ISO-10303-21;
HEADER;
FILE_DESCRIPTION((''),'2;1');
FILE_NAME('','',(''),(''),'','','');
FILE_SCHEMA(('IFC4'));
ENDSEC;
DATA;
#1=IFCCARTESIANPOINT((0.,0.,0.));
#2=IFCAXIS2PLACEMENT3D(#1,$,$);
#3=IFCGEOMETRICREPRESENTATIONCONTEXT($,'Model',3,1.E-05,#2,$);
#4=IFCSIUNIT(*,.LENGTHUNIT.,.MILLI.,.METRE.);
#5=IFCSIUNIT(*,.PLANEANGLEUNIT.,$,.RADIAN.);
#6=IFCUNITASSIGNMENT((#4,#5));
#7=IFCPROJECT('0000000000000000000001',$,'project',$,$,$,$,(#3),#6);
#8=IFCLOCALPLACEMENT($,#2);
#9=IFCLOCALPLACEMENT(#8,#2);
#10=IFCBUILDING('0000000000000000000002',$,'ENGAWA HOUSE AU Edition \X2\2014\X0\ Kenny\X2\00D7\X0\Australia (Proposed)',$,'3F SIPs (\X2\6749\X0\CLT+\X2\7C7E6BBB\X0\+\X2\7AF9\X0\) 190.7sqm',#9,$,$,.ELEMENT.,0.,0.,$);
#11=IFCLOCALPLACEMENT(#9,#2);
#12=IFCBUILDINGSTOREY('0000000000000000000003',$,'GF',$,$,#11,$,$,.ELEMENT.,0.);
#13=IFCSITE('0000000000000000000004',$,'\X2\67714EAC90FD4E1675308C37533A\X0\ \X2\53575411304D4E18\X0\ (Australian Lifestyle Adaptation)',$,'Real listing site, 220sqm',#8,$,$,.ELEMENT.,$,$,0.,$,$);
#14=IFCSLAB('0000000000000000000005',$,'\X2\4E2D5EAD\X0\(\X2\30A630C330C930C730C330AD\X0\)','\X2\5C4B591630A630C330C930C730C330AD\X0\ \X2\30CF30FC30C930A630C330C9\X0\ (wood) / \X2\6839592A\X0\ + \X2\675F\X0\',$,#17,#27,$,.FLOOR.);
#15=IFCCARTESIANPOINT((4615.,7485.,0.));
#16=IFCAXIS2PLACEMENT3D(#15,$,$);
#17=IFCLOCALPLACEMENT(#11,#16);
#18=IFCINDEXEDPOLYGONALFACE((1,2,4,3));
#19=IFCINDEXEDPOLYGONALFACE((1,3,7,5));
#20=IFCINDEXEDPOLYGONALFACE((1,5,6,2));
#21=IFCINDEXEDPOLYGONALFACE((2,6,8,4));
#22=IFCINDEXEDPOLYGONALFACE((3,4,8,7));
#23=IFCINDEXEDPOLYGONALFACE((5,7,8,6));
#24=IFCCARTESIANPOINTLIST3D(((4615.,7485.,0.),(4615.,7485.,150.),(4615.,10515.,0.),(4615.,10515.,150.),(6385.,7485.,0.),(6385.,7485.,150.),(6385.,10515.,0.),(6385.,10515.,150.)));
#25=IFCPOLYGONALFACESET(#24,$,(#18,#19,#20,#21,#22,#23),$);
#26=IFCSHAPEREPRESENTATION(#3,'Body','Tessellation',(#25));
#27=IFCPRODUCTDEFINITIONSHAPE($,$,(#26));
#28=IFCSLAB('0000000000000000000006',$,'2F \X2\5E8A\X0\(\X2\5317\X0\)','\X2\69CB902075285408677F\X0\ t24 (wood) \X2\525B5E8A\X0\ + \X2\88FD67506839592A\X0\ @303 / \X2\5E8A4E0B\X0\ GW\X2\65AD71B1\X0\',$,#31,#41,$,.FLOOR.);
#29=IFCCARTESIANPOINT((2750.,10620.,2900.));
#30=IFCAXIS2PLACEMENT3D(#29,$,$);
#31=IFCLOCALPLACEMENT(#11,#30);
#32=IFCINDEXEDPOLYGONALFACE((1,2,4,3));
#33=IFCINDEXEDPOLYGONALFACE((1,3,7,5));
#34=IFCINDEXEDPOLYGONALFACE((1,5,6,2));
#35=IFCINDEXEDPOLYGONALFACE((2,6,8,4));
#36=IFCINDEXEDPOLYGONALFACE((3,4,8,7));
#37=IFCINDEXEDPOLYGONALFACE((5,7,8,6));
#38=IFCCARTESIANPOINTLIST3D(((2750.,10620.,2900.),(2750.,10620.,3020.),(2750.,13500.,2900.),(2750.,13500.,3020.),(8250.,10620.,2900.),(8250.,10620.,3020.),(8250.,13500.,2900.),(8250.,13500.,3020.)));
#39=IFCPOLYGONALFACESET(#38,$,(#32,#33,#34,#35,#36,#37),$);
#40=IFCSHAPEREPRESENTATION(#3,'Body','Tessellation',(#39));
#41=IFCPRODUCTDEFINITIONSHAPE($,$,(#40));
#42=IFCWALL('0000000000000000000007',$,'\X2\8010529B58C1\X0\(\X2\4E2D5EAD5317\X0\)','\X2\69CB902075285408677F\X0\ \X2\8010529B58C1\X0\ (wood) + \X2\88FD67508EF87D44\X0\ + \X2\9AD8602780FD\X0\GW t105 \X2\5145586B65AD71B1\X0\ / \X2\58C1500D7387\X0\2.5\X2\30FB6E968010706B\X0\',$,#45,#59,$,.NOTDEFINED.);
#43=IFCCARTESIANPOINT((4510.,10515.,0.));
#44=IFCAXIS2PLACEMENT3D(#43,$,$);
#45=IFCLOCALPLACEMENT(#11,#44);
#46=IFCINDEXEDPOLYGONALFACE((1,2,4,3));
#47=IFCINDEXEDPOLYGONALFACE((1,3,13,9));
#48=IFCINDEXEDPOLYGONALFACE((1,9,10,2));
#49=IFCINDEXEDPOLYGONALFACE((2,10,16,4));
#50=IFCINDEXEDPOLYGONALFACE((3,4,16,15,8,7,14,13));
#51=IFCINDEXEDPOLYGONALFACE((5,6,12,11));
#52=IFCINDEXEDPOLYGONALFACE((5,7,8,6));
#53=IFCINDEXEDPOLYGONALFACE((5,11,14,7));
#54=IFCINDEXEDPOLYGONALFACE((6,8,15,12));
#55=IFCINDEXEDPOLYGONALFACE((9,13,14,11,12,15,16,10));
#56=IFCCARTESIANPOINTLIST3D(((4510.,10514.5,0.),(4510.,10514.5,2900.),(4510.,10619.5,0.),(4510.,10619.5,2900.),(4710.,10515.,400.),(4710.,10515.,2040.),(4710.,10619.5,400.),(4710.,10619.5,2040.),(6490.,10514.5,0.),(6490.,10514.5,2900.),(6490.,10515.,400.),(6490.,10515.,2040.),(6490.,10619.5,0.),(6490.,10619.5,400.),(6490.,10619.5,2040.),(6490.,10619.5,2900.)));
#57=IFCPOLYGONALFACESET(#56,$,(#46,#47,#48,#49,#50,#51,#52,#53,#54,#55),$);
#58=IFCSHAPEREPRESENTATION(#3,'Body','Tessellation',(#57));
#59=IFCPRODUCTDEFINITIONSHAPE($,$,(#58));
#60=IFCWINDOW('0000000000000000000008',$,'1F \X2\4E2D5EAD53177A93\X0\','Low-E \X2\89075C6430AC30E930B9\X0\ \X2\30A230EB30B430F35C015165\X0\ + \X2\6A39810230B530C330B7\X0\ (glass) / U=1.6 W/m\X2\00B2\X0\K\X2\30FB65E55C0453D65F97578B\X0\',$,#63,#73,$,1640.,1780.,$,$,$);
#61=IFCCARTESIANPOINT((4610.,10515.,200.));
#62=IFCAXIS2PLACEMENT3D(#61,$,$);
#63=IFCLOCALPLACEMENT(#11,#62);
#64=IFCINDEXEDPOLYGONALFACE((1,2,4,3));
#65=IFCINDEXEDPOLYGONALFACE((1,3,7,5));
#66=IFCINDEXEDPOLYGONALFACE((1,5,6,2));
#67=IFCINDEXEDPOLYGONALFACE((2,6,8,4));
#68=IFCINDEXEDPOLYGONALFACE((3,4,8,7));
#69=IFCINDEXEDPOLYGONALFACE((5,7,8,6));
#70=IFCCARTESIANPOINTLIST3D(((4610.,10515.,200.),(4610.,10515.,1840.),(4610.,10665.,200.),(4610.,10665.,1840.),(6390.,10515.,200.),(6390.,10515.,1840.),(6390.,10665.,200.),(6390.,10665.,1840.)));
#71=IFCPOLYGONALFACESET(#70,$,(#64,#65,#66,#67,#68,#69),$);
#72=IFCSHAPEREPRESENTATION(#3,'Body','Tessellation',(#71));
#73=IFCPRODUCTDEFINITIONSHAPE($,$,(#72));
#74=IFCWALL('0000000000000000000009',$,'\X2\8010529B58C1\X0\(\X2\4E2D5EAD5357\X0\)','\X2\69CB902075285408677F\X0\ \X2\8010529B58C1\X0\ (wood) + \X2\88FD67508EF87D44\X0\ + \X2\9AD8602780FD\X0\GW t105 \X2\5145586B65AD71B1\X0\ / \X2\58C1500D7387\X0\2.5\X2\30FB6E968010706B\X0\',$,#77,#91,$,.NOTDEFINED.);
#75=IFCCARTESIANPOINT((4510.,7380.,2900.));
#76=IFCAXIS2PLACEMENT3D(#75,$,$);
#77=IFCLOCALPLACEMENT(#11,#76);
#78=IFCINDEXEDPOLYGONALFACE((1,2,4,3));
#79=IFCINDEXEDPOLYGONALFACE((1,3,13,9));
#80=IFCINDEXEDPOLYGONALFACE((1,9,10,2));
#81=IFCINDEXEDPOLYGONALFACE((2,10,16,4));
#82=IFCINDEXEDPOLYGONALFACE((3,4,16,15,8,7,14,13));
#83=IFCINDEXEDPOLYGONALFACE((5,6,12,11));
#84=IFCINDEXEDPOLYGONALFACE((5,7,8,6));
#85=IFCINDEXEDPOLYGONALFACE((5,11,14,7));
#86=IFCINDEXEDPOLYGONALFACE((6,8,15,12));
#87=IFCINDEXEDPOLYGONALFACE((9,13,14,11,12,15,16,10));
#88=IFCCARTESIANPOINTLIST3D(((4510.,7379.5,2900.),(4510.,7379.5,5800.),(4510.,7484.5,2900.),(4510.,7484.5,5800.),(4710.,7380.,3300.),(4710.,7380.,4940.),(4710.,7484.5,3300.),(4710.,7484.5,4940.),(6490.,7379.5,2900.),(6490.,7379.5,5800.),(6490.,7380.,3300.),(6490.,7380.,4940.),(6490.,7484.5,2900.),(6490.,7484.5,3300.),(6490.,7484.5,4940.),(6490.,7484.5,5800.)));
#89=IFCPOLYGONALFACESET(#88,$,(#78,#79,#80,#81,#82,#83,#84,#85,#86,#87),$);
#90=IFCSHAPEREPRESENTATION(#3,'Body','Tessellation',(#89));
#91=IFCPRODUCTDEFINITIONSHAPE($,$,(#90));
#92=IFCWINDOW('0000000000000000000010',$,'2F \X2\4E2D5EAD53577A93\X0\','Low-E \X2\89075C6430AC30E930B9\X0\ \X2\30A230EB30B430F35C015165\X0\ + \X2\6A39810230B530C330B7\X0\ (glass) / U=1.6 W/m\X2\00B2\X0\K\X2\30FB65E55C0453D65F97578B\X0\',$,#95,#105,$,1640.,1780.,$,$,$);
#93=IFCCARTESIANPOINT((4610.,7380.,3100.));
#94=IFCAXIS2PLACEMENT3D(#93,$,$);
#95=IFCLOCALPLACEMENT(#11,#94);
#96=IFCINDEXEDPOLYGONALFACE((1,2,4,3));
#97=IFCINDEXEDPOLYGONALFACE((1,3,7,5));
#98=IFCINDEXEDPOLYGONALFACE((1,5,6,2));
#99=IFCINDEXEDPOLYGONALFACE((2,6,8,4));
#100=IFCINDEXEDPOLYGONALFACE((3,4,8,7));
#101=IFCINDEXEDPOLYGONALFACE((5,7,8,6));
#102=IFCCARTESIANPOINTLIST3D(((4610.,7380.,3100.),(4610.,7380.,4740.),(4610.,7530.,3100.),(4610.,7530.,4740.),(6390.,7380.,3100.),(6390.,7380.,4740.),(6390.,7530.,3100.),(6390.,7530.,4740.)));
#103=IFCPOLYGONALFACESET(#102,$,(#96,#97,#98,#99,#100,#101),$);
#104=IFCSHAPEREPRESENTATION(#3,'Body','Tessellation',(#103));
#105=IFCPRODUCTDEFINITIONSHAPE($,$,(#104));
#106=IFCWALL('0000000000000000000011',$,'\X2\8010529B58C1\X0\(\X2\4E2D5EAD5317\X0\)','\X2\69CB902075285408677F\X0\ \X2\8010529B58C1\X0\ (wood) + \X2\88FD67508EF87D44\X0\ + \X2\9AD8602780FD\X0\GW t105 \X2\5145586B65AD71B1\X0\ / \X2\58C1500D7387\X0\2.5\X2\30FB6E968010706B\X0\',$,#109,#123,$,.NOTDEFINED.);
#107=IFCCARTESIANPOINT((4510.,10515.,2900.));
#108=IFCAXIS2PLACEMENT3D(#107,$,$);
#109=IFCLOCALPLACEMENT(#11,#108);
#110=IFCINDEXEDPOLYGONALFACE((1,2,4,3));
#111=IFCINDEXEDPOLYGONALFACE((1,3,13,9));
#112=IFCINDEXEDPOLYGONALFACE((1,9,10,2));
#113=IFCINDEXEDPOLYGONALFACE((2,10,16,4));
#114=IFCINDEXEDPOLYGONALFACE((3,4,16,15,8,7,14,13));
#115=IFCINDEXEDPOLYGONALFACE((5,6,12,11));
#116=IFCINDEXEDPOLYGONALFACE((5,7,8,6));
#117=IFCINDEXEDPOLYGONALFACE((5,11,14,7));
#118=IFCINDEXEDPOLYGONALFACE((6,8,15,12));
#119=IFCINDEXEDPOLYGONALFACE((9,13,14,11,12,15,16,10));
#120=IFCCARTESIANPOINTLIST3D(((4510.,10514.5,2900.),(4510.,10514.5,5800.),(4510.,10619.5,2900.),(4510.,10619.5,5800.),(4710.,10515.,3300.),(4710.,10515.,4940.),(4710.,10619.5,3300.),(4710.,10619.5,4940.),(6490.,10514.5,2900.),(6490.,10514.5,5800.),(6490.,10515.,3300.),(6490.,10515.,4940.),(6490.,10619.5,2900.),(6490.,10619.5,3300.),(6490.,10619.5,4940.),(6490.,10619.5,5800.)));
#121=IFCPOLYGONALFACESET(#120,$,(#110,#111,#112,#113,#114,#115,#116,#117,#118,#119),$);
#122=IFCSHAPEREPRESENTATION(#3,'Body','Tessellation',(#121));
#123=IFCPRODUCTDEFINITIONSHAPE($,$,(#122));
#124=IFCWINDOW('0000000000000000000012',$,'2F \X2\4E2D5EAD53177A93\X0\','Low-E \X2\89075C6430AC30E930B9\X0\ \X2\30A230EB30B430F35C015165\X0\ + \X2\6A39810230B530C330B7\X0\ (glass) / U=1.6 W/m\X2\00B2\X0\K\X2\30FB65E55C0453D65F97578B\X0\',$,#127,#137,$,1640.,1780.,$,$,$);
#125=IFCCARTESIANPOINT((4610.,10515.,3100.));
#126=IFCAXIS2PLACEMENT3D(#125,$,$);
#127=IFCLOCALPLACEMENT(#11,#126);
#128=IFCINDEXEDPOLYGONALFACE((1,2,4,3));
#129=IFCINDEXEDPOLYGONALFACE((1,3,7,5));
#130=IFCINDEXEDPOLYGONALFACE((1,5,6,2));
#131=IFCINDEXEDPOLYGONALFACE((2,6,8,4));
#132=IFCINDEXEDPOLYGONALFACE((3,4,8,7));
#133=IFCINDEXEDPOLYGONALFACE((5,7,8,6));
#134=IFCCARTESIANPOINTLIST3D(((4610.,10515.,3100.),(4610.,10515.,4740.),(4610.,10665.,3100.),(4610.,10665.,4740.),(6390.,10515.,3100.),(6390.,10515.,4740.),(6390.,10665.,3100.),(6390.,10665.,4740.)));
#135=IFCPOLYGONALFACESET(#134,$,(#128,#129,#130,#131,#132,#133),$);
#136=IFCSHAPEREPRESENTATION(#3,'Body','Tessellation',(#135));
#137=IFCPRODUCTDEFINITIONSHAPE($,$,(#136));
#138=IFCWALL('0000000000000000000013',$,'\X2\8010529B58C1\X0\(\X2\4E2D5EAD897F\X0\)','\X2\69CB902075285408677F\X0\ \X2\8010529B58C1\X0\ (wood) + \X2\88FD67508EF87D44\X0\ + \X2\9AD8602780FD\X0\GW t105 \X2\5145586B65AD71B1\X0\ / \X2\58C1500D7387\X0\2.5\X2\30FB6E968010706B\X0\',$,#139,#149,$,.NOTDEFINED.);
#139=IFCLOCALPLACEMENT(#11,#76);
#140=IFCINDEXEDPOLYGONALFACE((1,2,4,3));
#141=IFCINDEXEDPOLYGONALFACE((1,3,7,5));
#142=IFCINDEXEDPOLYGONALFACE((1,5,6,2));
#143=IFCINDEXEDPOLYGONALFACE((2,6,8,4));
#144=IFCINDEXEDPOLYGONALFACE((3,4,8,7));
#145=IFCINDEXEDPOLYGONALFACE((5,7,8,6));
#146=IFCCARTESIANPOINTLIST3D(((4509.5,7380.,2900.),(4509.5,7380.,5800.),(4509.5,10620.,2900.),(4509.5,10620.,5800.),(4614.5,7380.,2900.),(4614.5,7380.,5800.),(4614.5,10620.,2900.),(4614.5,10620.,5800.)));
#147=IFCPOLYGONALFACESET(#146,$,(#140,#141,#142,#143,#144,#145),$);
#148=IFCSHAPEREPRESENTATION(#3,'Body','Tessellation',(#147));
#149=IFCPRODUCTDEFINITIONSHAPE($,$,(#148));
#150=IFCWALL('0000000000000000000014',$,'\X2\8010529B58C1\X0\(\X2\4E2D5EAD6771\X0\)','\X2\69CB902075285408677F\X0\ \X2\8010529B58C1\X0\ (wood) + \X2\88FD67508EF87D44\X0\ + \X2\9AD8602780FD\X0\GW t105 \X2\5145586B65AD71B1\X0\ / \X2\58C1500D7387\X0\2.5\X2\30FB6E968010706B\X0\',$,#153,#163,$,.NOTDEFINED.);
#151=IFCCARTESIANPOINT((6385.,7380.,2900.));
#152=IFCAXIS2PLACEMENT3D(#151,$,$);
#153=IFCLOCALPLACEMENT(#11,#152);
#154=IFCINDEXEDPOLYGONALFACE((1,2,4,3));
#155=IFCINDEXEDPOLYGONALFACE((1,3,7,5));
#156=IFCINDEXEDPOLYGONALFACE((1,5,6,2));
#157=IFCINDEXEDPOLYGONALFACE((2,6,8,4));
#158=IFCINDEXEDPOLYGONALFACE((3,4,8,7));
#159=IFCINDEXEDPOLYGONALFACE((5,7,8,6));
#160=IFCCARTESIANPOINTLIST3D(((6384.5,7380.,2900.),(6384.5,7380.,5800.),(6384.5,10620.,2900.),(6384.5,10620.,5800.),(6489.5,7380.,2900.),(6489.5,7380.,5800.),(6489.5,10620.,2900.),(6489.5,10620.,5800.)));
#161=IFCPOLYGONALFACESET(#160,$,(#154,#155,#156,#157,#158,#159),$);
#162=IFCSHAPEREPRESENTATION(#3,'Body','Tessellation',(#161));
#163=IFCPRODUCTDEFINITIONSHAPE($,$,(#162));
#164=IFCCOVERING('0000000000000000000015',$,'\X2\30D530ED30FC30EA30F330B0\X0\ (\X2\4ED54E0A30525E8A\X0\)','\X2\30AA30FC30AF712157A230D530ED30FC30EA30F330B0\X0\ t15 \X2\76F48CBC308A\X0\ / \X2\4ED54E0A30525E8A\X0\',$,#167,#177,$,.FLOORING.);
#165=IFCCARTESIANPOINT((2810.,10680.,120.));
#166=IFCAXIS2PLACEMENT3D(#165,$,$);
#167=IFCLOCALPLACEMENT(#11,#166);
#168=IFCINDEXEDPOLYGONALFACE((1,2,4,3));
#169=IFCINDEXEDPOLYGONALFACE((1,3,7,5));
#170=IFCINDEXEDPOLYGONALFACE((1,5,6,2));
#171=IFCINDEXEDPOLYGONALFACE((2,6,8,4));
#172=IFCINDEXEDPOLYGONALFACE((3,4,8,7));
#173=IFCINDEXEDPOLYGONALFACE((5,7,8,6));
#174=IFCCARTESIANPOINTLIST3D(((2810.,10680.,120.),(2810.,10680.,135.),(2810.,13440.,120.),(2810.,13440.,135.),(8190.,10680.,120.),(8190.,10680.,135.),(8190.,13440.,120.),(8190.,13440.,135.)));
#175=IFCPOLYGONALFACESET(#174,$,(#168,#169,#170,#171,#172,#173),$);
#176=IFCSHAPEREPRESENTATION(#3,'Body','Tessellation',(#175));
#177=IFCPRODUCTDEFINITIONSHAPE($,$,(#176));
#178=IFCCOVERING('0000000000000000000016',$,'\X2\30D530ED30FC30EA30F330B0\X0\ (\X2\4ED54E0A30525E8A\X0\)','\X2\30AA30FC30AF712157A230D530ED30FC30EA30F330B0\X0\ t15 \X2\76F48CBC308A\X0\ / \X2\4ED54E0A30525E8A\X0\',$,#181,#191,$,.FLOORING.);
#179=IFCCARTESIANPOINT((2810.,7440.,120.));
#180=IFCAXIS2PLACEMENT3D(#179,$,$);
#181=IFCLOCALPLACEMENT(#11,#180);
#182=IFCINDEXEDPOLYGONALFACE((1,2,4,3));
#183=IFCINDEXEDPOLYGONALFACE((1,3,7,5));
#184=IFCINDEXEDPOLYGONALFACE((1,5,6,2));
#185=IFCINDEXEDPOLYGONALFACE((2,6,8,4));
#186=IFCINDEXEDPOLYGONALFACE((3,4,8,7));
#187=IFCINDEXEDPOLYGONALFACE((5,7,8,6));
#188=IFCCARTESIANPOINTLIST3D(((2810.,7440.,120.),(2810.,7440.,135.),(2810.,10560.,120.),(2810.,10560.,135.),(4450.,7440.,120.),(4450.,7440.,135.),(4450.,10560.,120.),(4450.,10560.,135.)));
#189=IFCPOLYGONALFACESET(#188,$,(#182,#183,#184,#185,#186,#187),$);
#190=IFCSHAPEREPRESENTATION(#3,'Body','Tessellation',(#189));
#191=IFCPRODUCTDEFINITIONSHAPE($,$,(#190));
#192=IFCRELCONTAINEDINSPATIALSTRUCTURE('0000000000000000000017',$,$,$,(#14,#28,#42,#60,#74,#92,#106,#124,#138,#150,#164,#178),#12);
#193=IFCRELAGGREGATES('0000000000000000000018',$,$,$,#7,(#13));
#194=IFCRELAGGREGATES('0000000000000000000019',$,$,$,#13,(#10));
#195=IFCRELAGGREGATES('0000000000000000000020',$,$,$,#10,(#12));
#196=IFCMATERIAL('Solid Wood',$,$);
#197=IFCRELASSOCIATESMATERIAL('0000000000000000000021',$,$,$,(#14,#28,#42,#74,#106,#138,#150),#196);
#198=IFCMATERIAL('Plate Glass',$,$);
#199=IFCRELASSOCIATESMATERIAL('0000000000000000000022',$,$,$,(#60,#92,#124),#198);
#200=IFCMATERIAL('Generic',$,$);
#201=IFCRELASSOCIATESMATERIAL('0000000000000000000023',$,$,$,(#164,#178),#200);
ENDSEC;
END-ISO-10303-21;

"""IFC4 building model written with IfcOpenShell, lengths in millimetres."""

from ifc_helpers import new_model, si_unit, frame, frame_2d, origin, place, context, project, spatial, rectangle, extrude, material, element, fill, save


model = new_model("IFC4")

# Units and contexts
model_context = context("Model", 3, precision=1e-05, world=origin())
ifc_project = project(units=[si_unit("LENGTHUNIT", "METRE", prefix="MILLI"), si_unit("PLANEANGLEUNIT", "RADIAN")], contexts=[model_context])

# Site, building, storey
site_placement = place(None, origin())
site = spatial("IfcSite", under=ifc_project, at=site_placement, Name="東京都世田谷区 南向き丘 (Australian Lifestyle Adaptation)", ObjectType="Real listing site, 220sqm", CompositionType="ELEMENT", RefElevation=0.0)
building_placement = place(site_placement, origin())
building = spatial("IfcBuilding", under=site, at=building_placement, Name="ENGAWA HOUSE AU Edition — Kenny×Australia (Proposed)", ObjectType="3F SIPs (杉CLT+籾殻+竹) 190.7sqm", CompositionType="ELEMENT", ElevationOfRefHeight=0.0, ElevationOfTerrain=0.0)
storey_placement = place(building_placement, origin())
storey = spatial("IfcBuildingStorey", under=building, at=storey_placement, Name="GF", CompositionType="ELEMENT", Elevation=0.0)

# Slabs
ifc_material_1 = material(Name="Solid Wood")
slab_1_placement = place(storey_placement, frame((4615.0, 7485.0, 0.0)))
element("IfcSlab", 1, at=slab_1_placement, inside=storey, material=ifc_material_1, Name="中庭(ウッドデッキ)", Description="屋外ウッドデッキ ハードウッド (wood) / 根太 + 束", PredefinedType="FLOOR", context=model_context, shape_type="SweptSolid", body=[
    extrude(rectangle(XDim=1770.0, YDim=3030.0, at=frame_2d((885.0, 1515.0))), frame((4615.0, 7485.0, 0.0)), (0.0, 0.0, 1.0), 150.0),
])
slab_2_placement = place(storey_placement, frame((2750.0, 10620.0, 2900.0)))
element("IfcSlab", 2, at=slab_2_placement, inside=storey, material=ifc_material_1, Name="2F 床(北)", Description="構造用合板 t24 (wood) 剛床 + 製材根太 @303 / 床下 GW断熱", PredefinedType="FLOOR", context=model_context, shape_type="SweptSolid", body=[
    extrude(rectangle(XDim=5500.0, YDim=2880.0, at=frame_2d((2750.0, 1440.0))), frame((2750.0, 10620.0, 2900.0)), (0.0, 0.0, 1.0), 120.0),
])

# Wall, opening, window
wall_1_placement = place(storey_placement, frame((4510.0, 10515.0, 0.0)))
wall_1 = element("IfcWall", 3, at=wall_1_placement, inside=storey, material=ifc_material_1, Name="耐力壁(中庭北)", Description="構造用合板 耐力壁 (wood) + 製材軸組 + 高性能GW t105 充填断熱 / 壁倍率2.5・準耐火", PredefinedType="NOTDEFINED", context=model_context, shape_type="SweptSolid", body=[
    extrude(rectangle(XDim=1980.0, YDim=105.0, at=frame_2d((990.0, 52.0))), frame((4510.0, 10515.0, 0.0)), (0.0, 0.0, 1.0), 2900.0),
])
opening_1_placement = place(storey_placement, frame((4610.0, 10515.0, 200.0)))
opening_1 = element("IfcOpeningElement", 4, at=opening_1_placement, cuts=wall_1, PredefinedType="NOTDEFINED", context=model_context, shape_type="SweptSolid", body=[
    extrude(rectangle(XDim=1780.0, YDim=150.0, at=frame_2d((890.0, 75.0))), frame((4610.0, 10515.0, 200.0)), (0.0, 0.0, 1.0), 1640.0),
])
ifc_material_2 = material(Name="Plate Glass")
window_1_placement = place(storey_placement, frame((4610.0, 10515.0, 200.0)))
window_1 = element("IfcWindow", 5, at=window_1_placement, inside=storey, material=ifc_material_2, Name="1F 中庭北窓", Description="Low-E 複層ガラス アルゴン封入 + 樹脂サッシ (glass) / U=1.6 W/m²K・日射取得型", OverallHeight=1640.0, OverallWidth=1780.0, context=model_context, shape_type="SweptSolid", body=[
    extrude(rectangle(XDim=1780.0, YDim=150.0, at=frame_2d((890.0, 75.0))), frame((4610.0, 10515.0, 200.0)), (0.0, 0.0, 1.0), 1640.0),
])
fill(opening_1, window_1)

# Walls, openings, windows
wall_2_placement = place(storey_placement, frame((4510.0, 7380.0, 2900.0)))
wall_2 = element("IfcWall", 6, at=wall_2_placement, inside=storey, material=ifc_material_1, Name="耐力壁(中庭南)", Description="構造用合板 耐力壁 (wood) + 製材軸組 + 高性能GW t105 充填断熱 / 壁倍率2.5・準耐火", PredefinedType="NOTDEFINED", context=model_context, shape_type="SweptSolid", body=[
    extrude(rectangle(XDim=1980.0, YDim=105.0, at=frame_2d((990.0, 52.0))), frame((4510.0, 7380.0, 2900.0)), (0.0, 0.0, 1.0), 2900.0),
])
opening_2_placement = place(storey_placement, frame((4610.0, 7380.0, 3100.0)))
opening_2 = element("IfcOpeningElement", 7, at=opening_2_placement, cuts=wall_2, PredefinedType="NOTDEFINED", context=model_context, shape_type="SweptSolid", body=[
    extrude(rectangle(XDim=1780.0, YDim=150.0, at=frame_2d((890.0, 75.0))), frame((4610.0, 7380.0, 3100.0)), (0.0, 0.0, 1.0), 1640.0),
])
window_2_placement = place(storey_placement, frame((4610.0, 7380.0, 3100.0)))
window_2 = element("IfcWindow", 8, at=window_2_placement, inside=storey, material=ifc_material_2, Name="2F 中庭南窓", Description="Low-E 複層ガラス アルゴン封入 + 樹脂サッシ (glass) / U=1.6 W/m²K・日射取得型", OverallHeight=1640.0, OverallWidth=1780.0, context=model_context, shape_type="SweptSolid", body=[
    extrude(rectangle(XDim=1780.0, YDim=150.0, at=frame_2d((890.0, 75.0))), frame((4610.0, 7380.0, 3100.0)), (0.0, 0.0, 1.0), 1640.0),
])
fill(opening_2, window_2)
wall_3_placement = place(storey_placement, frame((4510.0, 10515.0, 2900.0)))
wall_3 = element("IfcWall", 9, at=wall_3_placement, inside=storey, material=ifc_material_1, Name="耐力壁(中庭北)", Description="構造用合板 耐力壁 (wood) + 製材軸組 + 高性能GW t105 充填断熱 / 壁倍率2.5・準耐火", PredefinedType="NOTDEFINED", context=model_context, shape_type="SweptSolid", body=[
    extrude(rectangle(XDim=1980.0, YDim=105.0, at=frame_2d((990.0, 52.0))), frame((4510.0, 10515.0, 2900.0)), (0.0, 0.0, 1.0), 2900.0),
])
opening_3_placement = place(storey_placement, frame((4610.0, 10515.0, 3100.0)))
opening_3 = element("IfcOpeningElement", 10, at=opening_3_placement, cuts=wall_3, PredefinedType="NOTDEFINED", context=model_context, shape_type="SweptSolid", body=[
    extrude(rectangle(XDim=1780.0, YDim=150.0, at=frame_2d((890.0, 75.0))), frame((4610.0, 10515.0, 3100.0)), (0.0, 0.0, 1.0), 1640.0),
])
window_3_placement = place(storey_placement, frame((4610.0, 10515.0, 3100.0)))
window_3 = element("IfcWindow", 11, at=window_3_placement, inside=storey, material=ifc_material_2, Name="2F 中庭北窓", Description="Low-E 複層ガラス アルゴン封入 + 樹脂サッシ (glass) / U=1.6 W/m²K・日射取得型", OverallHeight=1640.0, OverallWidth=1780.0, context=model_context, shape_type="SweptSolid", body=[
    extrude(rectangle(XDim=1780.0, YDim=150.0, at=frame_2d((890.0, 75.0))), frame((4610.0, 10515.0, 3100.0)), (0.0, 0.0, 1.0), 1640.0),
])
fill(opening_3, window_3)

# Walls
wall_4_placement = place(storey_placement, frame((4510.0, 7380.0, 2900.0)))
element("IfcWall", 12, at=wall_4_placement, inside=storey, material=ifc_material_1, Name="耐力壁(中庭西)", Description="構造用合板 耐力壁 (wood) + 製材軸組 + 高性能GW t105 充填断熱 / 壁倍率2.5・準耐火", PredefinedType="NOTDEFINED", context=model_context, shape_type="SweptSolid", body=[
    extrude(rectangle(XDim=105.0, YDim=3240.0, at=frame_2d((52.0, 1620.0))), frame((4510.0, 7380.0, 2900.0)), (0.0, 0.0, 1.0), 2900.0),
])
wall_5_placement = place(storey_placement, frame((6385.0, 7380.0, 2900.0)))
element("IfcWall", 13, at=wall_5_placement, inside=storey, material=ifc_material_1, Name="耐力壁(中庭東)", Description="構造用合板 耐力壁 (wood) + 製材軸組 + 高性能GW t105 充填断熱 / 壁倍率2.5・準耐火", PredefinedType="NOTDEFINED", context=model_context, shape_type="SweptSolid", body=[
    extrude(rectangle(XDim=105.0, YDim=3240.0, at=frame_2d((52.0, 1620.0))), frame((6385.0, 7380.0, 2900.0)), (0.0, 0.0, 1.0), 2900.0),
])

# Coverings
ifc_material_3 = material(Name="Generic")
covering_1_placement = place(storey_placement, frame((2810.0, 10680.0, 120.0)))
element("IfcCovering", 14, at=covering_1_placement, inside=storey, material=ifc_material_3, Name="フローリング (仕上げ床)", Description="オーク無垢フローリング t15 直貼り / 仕上げ床", PredefinedType="FLOORING", context=model_context, shape_type="SweptSolid", body=[
    extrude(rectangle(XDim=5380.0, YDim=2760.0, at=frame_2d((2690.0, 1380.0))), frame((2810.0, 10680.0, 120.0)), (0.0, 0.0, 1.0), 15.0),
])
covering_2_placement = place(storey_placement, frame((2810.0, 7440.0, 120.0)))
element("IfcCovering", 15, at=covering_2_placement, inside=storey, material=ifc_material_3, Name="フローリング (仕上げ床)", Description="オーク無垢フローリング t15 直貼り / 仕上げ床", PredefinedType="FLOORING", context=model_context, shape_type="SweptSolid", body=[
    extrude(rectangle(XDim=1640.0, YDim=3120.0, at=frame_2d((820.0, 1560.0))), frame((2810.0, 7440.0, 120.0)), (0.0, 0.0, 1.0), 15.0),
])

save(model, "model.ifc")
